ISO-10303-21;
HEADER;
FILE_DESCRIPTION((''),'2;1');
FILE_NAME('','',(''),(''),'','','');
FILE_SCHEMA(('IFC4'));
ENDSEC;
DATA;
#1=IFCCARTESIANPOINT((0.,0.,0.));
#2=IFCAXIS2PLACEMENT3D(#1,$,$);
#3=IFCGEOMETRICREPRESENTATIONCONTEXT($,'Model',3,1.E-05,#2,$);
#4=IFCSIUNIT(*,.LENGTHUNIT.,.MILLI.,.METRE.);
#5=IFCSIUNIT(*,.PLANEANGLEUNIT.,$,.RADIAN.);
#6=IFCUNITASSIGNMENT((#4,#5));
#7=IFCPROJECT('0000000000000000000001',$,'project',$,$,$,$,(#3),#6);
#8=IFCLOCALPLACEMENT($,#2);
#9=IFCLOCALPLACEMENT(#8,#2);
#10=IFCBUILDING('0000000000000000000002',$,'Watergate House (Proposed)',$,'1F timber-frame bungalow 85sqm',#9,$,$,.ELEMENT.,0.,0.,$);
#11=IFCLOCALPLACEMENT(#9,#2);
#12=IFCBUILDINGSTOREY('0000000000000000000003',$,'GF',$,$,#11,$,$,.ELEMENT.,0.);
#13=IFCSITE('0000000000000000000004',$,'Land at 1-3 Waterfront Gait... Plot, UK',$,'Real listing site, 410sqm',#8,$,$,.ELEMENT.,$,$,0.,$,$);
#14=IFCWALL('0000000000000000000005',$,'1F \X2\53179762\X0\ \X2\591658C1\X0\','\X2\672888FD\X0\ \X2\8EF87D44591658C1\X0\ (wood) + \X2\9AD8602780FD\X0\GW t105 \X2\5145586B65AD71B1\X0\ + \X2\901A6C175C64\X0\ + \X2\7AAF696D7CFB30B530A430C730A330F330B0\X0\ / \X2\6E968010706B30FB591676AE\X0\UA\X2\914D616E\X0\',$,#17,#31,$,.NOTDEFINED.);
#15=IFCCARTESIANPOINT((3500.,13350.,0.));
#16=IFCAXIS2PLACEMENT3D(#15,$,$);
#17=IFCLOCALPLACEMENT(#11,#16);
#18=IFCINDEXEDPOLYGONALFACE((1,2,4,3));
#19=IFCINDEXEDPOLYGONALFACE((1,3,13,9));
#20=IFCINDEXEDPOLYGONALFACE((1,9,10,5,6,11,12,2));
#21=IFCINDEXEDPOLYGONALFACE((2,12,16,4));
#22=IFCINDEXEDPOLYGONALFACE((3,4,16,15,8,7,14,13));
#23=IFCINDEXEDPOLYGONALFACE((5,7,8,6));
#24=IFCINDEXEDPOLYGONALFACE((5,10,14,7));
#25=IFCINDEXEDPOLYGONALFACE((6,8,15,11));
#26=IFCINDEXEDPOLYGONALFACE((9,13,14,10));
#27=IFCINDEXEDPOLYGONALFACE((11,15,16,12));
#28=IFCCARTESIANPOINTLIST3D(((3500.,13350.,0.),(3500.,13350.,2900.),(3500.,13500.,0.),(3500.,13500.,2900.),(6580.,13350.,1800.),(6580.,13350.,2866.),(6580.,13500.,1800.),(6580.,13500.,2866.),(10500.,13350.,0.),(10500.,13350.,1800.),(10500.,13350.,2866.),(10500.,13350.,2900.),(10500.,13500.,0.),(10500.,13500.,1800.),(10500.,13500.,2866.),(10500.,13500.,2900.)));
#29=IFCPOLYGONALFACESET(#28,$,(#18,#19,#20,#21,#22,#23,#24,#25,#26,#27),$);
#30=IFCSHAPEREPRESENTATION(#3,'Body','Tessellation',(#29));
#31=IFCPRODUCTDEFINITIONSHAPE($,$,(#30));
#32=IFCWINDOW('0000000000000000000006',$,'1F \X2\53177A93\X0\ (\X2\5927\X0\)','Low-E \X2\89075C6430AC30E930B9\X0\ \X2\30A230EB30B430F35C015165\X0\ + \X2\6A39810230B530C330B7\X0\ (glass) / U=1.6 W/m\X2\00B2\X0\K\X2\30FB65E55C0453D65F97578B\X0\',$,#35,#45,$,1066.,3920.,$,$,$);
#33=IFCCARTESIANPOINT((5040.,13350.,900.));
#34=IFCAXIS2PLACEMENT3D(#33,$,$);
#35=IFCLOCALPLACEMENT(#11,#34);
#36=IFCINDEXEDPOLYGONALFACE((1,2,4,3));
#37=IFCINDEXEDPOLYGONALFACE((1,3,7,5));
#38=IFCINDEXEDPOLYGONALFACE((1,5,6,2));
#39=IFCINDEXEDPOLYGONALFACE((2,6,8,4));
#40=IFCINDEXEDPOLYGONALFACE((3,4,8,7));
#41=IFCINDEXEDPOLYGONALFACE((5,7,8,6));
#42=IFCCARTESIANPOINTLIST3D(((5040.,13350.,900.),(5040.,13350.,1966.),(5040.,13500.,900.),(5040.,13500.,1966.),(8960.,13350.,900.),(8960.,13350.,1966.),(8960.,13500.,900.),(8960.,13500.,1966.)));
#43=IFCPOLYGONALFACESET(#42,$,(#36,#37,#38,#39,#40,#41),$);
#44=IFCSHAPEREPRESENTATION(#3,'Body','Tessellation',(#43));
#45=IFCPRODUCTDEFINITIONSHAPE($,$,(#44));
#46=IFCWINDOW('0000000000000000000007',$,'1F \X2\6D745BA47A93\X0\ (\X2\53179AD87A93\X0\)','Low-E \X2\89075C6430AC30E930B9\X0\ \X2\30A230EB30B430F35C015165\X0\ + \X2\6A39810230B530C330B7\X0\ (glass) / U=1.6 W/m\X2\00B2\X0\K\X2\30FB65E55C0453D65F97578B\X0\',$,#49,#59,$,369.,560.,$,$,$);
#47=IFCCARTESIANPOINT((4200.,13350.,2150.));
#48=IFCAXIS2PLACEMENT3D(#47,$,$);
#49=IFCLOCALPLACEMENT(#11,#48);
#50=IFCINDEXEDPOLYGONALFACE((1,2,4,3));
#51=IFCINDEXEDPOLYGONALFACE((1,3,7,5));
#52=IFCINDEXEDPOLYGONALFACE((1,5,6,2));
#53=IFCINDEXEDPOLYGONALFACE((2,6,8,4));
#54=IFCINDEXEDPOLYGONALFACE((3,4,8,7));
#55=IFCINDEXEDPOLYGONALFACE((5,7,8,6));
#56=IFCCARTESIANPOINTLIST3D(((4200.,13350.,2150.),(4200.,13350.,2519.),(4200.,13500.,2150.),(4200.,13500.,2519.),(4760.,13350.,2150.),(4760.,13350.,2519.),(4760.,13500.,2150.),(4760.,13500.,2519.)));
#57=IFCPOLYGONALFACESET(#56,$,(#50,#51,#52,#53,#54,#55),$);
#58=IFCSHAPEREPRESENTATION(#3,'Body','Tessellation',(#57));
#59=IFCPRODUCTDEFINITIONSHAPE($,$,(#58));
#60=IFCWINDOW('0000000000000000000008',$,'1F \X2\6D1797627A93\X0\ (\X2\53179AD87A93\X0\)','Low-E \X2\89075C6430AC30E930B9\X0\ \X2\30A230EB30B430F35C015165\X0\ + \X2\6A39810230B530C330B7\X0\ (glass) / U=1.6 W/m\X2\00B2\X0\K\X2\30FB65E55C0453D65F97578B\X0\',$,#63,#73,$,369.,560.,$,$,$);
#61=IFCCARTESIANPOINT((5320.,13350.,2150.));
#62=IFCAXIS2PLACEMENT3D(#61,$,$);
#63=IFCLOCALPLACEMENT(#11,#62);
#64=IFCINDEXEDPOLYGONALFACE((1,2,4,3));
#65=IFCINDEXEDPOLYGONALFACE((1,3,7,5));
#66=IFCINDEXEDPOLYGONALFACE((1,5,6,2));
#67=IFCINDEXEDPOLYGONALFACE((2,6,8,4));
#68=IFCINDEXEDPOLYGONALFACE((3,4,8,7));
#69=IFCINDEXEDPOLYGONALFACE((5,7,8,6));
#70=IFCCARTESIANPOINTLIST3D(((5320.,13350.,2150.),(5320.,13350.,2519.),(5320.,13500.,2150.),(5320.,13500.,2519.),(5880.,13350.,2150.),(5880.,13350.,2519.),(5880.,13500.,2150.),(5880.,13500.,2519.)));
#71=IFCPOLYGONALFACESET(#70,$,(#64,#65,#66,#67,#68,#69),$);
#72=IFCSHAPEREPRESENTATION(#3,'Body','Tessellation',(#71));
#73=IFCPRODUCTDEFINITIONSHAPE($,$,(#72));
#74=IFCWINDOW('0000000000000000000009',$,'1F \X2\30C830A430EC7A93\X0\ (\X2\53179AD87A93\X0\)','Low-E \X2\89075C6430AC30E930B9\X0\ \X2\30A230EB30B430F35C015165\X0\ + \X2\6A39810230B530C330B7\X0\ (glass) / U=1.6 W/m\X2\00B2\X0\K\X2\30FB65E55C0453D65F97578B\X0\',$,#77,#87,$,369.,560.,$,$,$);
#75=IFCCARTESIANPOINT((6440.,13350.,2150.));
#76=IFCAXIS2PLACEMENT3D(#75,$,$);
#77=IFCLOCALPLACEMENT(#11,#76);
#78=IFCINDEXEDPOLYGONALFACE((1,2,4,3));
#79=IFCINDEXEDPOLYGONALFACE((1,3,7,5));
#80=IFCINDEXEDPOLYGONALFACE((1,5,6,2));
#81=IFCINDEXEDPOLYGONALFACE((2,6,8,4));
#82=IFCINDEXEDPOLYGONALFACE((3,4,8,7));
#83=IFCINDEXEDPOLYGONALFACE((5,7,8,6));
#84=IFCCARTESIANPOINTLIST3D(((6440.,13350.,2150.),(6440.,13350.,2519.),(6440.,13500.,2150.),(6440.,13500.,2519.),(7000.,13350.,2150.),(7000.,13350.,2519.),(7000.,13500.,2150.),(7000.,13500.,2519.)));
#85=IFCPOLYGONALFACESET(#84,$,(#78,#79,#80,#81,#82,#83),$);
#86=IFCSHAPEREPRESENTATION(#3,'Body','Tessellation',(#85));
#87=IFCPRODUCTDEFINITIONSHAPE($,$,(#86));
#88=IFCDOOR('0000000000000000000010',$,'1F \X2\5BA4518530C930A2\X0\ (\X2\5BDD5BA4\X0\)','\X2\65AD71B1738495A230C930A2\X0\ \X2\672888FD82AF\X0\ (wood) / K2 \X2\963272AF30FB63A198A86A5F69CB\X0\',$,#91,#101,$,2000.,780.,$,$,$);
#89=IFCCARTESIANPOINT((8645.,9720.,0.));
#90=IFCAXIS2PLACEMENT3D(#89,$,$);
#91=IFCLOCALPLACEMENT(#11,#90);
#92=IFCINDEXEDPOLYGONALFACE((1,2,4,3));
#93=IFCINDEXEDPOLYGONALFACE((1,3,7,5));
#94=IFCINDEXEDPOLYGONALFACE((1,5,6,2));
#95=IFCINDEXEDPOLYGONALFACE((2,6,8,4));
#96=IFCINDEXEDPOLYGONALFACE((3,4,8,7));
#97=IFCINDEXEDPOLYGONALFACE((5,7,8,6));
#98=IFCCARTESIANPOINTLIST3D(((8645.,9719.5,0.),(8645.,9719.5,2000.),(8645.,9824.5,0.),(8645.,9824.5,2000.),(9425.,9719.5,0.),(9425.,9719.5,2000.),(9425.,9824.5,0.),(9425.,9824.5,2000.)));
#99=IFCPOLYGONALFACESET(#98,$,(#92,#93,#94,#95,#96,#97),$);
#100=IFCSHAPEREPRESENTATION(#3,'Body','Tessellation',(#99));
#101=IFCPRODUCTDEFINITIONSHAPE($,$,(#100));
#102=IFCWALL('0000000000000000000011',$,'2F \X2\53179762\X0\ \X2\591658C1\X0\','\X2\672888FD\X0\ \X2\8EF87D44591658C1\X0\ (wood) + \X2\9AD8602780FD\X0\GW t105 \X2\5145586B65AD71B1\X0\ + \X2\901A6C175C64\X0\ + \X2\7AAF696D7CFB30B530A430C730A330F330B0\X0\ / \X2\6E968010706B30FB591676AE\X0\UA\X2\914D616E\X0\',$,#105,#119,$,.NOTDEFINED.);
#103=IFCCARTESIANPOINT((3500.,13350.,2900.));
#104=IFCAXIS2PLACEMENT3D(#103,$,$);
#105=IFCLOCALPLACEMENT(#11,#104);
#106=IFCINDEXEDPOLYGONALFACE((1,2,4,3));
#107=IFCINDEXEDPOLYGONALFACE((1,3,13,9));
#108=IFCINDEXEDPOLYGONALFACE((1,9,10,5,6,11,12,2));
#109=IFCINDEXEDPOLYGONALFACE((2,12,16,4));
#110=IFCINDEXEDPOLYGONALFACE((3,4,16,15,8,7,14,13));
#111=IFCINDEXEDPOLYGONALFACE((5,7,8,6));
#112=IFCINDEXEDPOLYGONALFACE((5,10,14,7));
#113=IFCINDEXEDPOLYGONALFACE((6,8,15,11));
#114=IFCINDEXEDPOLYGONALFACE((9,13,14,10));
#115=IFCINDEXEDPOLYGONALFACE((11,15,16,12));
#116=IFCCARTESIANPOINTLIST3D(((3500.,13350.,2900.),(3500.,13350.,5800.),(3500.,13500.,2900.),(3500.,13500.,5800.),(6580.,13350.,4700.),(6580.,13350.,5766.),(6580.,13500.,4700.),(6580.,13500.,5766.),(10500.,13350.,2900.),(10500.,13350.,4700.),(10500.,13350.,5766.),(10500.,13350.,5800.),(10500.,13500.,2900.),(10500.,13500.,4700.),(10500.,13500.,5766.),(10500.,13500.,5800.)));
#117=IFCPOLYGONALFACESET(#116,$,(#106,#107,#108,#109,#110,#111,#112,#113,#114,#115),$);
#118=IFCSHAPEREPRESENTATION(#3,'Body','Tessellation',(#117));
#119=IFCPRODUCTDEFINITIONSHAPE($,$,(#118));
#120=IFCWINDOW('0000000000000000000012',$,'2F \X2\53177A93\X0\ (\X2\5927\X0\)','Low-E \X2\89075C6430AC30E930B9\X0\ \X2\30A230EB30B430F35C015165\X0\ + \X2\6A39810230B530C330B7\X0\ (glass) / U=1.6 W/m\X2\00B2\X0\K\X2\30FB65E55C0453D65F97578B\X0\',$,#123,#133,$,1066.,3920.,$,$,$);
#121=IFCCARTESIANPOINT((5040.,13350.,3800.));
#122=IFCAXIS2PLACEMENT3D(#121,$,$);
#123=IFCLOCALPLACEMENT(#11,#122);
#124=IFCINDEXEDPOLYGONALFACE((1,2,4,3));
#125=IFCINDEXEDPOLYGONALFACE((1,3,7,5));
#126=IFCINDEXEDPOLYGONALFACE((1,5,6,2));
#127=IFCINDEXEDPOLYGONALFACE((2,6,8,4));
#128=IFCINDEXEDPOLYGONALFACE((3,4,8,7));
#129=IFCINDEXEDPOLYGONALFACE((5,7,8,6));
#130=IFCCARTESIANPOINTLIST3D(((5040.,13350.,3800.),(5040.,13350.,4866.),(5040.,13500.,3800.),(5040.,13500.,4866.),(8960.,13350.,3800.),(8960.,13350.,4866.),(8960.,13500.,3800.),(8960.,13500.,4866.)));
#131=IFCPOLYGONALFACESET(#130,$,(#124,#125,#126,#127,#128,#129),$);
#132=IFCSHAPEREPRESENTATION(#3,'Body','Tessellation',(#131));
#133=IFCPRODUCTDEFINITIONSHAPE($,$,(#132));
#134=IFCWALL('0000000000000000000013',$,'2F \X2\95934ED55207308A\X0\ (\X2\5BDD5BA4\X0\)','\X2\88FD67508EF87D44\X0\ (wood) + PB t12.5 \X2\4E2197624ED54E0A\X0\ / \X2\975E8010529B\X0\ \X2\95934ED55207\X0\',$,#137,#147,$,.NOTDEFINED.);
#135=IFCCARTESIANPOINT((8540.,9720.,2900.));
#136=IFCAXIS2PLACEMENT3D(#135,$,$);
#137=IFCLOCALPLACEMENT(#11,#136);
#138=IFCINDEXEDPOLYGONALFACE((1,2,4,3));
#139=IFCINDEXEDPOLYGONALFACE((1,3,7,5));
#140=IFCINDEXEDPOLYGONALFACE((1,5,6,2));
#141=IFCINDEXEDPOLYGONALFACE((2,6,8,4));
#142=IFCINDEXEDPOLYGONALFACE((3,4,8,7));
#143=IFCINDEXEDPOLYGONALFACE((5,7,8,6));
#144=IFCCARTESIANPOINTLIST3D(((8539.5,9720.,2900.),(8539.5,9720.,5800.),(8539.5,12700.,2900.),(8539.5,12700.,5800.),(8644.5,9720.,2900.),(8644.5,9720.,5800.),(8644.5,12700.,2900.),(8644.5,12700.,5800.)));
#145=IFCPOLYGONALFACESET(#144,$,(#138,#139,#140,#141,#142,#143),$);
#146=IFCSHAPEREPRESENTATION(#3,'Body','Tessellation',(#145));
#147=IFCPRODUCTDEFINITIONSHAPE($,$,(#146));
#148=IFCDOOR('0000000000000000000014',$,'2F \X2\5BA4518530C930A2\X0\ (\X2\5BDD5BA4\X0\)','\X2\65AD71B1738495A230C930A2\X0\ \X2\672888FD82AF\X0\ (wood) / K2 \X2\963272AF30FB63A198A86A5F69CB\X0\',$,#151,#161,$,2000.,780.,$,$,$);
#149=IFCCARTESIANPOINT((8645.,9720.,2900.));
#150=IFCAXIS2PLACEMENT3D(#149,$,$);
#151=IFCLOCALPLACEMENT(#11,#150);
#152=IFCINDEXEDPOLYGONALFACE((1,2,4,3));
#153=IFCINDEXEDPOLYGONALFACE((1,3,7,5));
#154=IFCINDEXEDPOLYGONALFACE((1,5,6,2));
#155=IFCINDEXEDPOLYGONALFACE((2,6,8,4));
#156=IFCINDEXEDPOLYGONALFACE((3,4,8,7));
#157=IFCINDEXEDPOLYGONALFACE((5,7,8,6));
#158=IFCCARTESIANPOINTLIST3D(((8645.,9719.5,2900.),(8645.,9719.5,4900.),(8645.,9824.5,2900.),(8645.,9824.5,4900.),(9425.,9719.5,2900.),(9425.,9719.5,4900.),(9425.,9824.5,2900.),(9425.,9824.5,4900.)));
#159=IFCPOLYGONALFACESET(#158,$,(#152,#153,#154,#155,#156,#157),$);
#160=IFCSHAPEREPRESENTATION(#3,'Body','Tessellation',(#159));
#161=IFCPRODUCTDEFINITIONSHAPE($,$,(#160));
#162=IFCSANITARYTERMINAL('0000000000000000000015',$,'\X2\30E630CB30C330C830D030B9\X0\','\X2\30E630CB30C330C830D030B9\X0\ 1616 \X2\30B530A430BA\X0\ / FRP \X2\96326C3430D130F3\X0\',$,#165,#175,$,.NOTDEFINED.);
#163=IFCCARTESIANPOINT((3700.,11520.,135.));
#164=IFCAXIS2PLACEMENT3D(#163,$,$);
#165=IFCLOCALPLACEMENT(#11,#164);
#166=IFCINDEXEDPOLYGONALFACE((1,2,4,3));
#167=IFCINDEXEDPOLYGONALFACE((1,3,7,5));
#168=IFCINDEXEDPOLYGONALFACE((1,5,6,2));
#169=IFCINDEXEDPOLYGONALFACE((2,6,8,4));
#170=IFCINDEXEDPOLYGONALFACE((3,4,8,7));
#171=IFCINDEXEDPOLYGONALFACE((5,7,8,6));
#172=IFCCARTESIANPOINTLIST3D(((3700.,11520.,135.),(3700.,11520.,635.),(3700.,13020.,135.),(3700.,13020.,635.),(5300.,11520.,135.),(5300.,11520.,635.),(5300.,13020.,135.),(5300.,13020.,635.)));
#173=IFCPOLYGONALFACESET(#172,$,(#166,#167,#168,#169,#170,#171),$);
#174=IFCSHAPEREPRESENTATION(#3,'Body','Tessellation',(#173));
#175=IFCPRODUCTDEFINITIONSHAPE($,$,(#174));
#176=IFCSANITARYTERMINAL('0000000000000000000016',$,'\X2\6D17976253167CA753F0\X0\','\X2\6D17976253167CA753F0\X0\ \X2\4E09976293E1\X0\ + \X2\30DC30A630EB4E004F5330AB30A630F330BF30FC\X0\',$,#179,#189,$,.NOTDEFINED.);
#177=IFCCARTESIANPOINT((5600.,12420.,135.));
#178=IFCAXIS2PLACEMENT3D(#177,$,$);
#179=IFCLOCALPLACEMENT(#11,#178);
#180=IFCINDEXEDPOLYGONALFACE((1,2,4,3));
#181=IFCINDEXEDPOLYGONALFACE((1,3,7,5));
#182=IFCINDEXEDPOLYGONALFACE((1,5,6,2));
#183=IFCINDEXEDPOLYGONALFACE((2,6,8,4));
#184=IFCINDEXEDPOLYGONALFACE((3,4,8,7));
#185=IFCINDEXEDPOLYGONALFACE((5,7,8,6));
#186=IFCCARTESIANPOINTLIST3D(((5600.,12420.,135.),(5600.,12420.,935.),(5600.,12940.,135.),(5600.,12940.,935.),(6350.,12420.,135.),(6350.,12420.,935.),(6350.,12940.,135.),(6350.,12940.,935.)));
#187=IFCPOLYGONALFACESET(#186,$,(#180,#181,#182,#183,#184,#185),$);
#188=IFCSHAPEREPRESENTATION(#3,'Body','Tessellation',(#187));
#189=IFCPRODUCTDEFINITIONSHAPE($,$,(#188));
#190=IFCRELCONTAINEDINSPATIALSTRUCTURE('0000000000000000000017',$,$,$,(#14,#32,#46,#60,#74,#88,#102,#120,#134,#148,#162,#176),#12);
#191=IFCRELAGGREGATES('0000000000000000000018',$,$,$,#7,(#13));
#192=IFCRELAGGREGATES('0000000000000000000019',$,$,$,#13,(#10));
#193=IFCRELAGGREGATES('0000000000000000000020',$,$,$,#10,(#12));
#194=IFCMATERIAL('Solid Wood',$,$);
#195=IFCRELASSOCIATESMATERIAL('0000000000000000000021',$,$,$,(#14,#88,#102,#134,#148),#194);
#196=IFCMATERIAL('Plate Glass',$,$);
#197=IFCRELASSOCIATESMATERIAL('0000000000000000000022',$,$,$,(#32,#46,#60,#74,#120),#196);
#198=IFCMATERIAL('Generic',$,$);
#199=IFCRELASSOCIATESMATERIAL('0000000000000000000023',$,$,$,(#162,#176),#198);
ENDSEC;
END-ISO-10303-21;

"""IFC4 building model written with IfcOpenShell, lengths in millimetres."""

from ifc_helpers import new_model, si_unit, frame, frame_2d, origin, place, context, project, spatial, rectangle, extrude, material, element, fill, save


model = new_model("IFC4")

# Units and contexts
model_context = context("Model", 3, precision=1e-05, world=origin())
ifc_project = project(units=[si_unit("LENGTHUNIT", "METRE", prefix="MILLI"), si_unit("PLANEANGLEUNIT", "RADIAN")], contexts=[model_context])

# Site, building, storey
site_placement = place(None, origin())
site = spatial("IfcSite", under=ifc_project, at=site_placement, Name="Land at 1-3 Waterfront Gait... Plot, UK", ObjectType="Real listing site, 410sqm", CompositionType="ELEMENT", RefElevation=0.0)
building_placement = place(site_placement, origin())
building = spatial("IfcBuilding", under=site, at=building_placement, Name="Watergate House (Proposed)", ObjectType="1F timber-frame bungalow 85sqm", CompositionType="ELEMENT", ElevationOfRefHeight=0.0, ElevationOfTerrain=0.0)
storey_placement = place(building_placement, origin())
storey = spatial("IfcBuildingStorey", under=building, at=storey_placement, Name="GF", CompositionType="ELEMENT", Elevation=0.0)

# Wall, openings, windows
ifc_material_1 = material(Name="Solid Wood")
wall_1_placement = place(storey_placement, frame((3500.0, 13350.0, 0.0)))
wall_1 = element("IfcWall", 1, at=wall_1_placement, inside=storey, material=ifc_material_1, Name="1F 北面 外壁", Description="木製 軸組外壁 (wood) + 高性能GW t105 充填断熱 + 通気層 + 窯業系サイディング / 準耐火・外皮UA配慮", PredefinedType="NOTDEFINED", context=model_context, shape_type="SweptSolid", body=[
    extrude(rectangle(XDim=7000.0, YDim=150.0, at=frame_2d((3500.0, 75.0))), frame((3500.0, 13350.0, 0.0)), (0.0, 0.0, 1.0), 2900.0),
])
opening_1_placement = place(storey_placement, frame((5040.0, 13350.0, 900.0)))
opening_1 = element("IfcOpeningElement", 2, at=opening_1_placement, cuts=wall_1, PredefinedType="NOTDEFINED", context=model_context, shape_type="SweptSolid", body=[
    extrude(rectangle(XDim=3920.0, YDim=150.0, at=frame_2d((1960.0, 75.0))), frame((5040.0, 13350.0, 900.0)), (0.0, 0.0, 1.0), 1066.0),
])
opening_2_placement = place(storey_placement, frame((4200.0, 13350.0, 2150.0)))
opening_2 = element("IfcOpeningElement", 3, at=opening_2_placement, cuts=wall_1, PredefinedType="NOTDEFINED", context=model_context, shape_type="SweptSolid", body=[
    extrude(rectangle(XDim=560.0, YDim=150.0, at=frame_2d((280.0, 75.0))), frame((4200.0, 13350.0, 2150.0)), (0.0, 0.0, 1.0), 369.0),
])
opening_3_placement = place(storey_placement, frame((5320.0, 13350.0, 2150.0)))
opening_3 = element("IfcOpeningElement", 4, at=opening_3_placement, cuts=wall_1, PredefinedType="NOTDEFINED", context=model_context, shape_type="SweptSolid", body=[
    extrude(rectangle(XDim=560.0, YDim=150.0, at=frame_2d((280.0, 75.0))), frame((5320.0, 13350.0, 2150.0)), (0.0, 0.0, 1.0), 369.0),
])
opening_4_placement = place(storey_placement, frame((6440.0, 13350.0, 2150.0)))
opening_4 = element("IfcOpeningElement", 5, at=opening_4_placement, cuts=wall_1, PredefinedType="NOTDEFINED", context=model_context, shape_type="SweptSolid", body=[
    extrude(rectangle(XDim=560.0, YDim=150.0, at=frame_2d((280.0, 75.0))), frame((6440.0, 13350.0, 2150.0)), (0.0, 0.0, 1.0), 369.0),
])
ifc_material_2 = material(Name="Plate Glass")
window_1_placement = place(storey_placement, frame((5040.0, 13350.0, 900.0)))
window_1 = element("IfcWindow", 6, at=window_1_placement, inside=storey, material=ifc_material_2, Name="1F 北窓 (大)", Description="Low-E 複層ガラス アルゴン封入 + 樹脂サッシ (glass) / U=1.6 W/m²K・日射取得型", OverallHeight=1066.0, OverallWidth=3920.0, context=model_context, shape_type="SweptSolid", body=[
    extrude(rectangle(XDim=3920.0, YDim=150.0, at=frame_2d((1960.0, 75.0))), frame((5040.0, 13350.0, 900.0)), (0.0, 0.0, 1.0), 1066.0),
])
fill(opening_1, window_1)
window_2_placement = place(storey_placement, frame((4200.0, 13350.0, 2150.0)))
window_2 = element("IfcWindow", 7, at=window_2_placement, inside=storey, material=ifc_material_2, Name="1F 浴室窓 (北高窓)", Description="Low-E 複層ガラス アルゴン封入 + 樹脂サッシ (glass) / U=1.6 W/m²K・日射取得型", OverallHeight=369.0, OverallWidth=560.0, context=model_context, shape_type="SweptSolid", body=[
    extrude(rectangle(XDim=560.0, YDim=150.0, at=frame_2d((280.0, 75.0))), frame((4200.0, 13350.0, 2150.0)), (0.0, 0.0, 1.0), 369.0),
])
fill(opening_2, window_2)
window_3_placement = place(storey_placement, frame((5320.0, 13350.0, 2150.0)))
window_3 = element("IfcWindow", 8, at=window_3_placement, inside=storey, material=ifc_material_2, Name="1F 洗面窓 (北高窓)", Description="Low-E 複層ガラス アルゴン封入 + 樹脂サッシ (glass) / U=1.6 W/m²K・日射取得型", OverallHeight=369.0, OverallWidth=560.0, context=model_context, shape_type="SweptSolid", body=[
    extrude(rectangle(XDim=560.0, YDim=150.0, at=frame_2d((280.0, 75.0))), frame((5320.0, 13350.0, 2150.0)), (0.0, 0.0, 1.0), 369.0),
])
fill(opening_3, window_3)
window_4_placement = place(storey_placement, frame((6440.0, 13350.0, 2150.0)))
window_4 = element("IfcWindow", 9, at=window_4_placement, inside=storey, material=ifc_material_2, Name="1F トイレ窓 (北高窓)", Description="Low-E 複層ガラス アルゴン封入 + 樹脂サッシ (glass) / U=1.6 W/m²K・日射取得型", OverallHeight=369.0, OverallWidth=560.0, context=model_context, shape_type="SweptSolid", body=[
    extrude(rectangle(XDim=560.0, YDim=150.0, at=frame_2d((280.0, 75.0))), frame((6440.0, 13350.0, 2150.0)), (0.0, 0.0, 1.0), 369.0),
])
fill(opening_4, window_4)

# Door
door_1_placement = place(storey_placement, frame((8645.0, 9720.0, 0.0)))
element("IfcDoor", 10, at=door_1_placement, inside=storey, material=ifc_material_1, Name="1F 室内ドア (寝室)", Description="断熱玄関ドア 木製芯 (wood) / K2 防犯・採風機構", OverallHeight=2000.0, OverallWidth=780.0, context=model_context, shape_type="SweptSolid", body=[
    extrude(rectangle(XDim=780.0, YDim=105.0, at=frame_2d((390.0, 52.0))), frame((8645.0, 9720.0, 0.0)), (0.0, 0.0, 1.0), 2000.0),
])

# Wall, opening, window
wall_2_placement = place(storey_placement, frame((3500.0, 13350.0, 2900.0)))
wall_2 = element("IfcWall", 11, at=wall_2_placement, inside=storey, material=ifc_material_1, Name="2F 北面 外壁", Description="木製 軸組外壁 (wood) + 高性能GW t105 充填断熱 + 通気層 + 窯業系サイディング / 準耐火・外皮UA配慮", PredefinedType="NOTDEFINED", context=model_context, shape_type="SweptSolid", body=[
    extrude(rectangle(XDim=7000.0, YDim=150.0, at=frame_2d((3500.0, 75.0))), frame((3500.0, 13350.0, 2900.0)), (0.0, 0.0, 1.0), 2900.0),
])
opening_5_placement = place(storey_placement, frame((5040.0, 13350.0, 3800.0)))
opening_5 = element("IfcOpeningElement", 12, at=opening_5_placement, cuts=wall_2, PredefinedType="NOTDEFINED", context=model_context, shape_type="SweptSolid", body=[
    extrude(rectangle(XDim=3920.0, YDim=150.0, at=frame_2d((1960.0, 75.0))), frame((5040.0, 13350.0, 3800.0)), (0.0, 0.0, 1.0), 1066.0),
])
window_5_placement = place(storey_placement, frame((5040.0, 13350.0, 3800.0)))
window_5 = element("IfcWindow", 13, at=window_5_placement, inside=storey, material=ifc_material_2, Name="2F 北窓 (大)", Description="Low-E 複層ガラス アルゴン封入 + 樹脂サッシ (glass) / U=1.6 W/m²K・日射取得型", OverallHeight=1066.0, OverallWidth=3920.0, context=model_context, shape_type="SweptSolid", body=[
    extrude(rectangle(XDim=3920.0, YDim=150.0, at=frame_2d((1960.0, 75.0))), frame((5040.0, 13350.0, 3800.0)), (0.0, 0.0, 1.0), 1066.0),
])
fill(opening_5, window_5)

# Wall
wall_3_placement = place(storey_placement, frame((8540.0, 9720.0, 2900.0)))
element("IfcWall", 14, at=wall_3_placement, inside=storey, material=ifc_material_1, Name="2F 間仕切り (寝室)", Description="製材軸組 (wood) + PB t12.5 両面仕上 / 非耐力 間仕切", PredefinedType="NOTDEFINED", context=model_context, shape_type="SweptSolid", body=[
    extrude(rectangle(XDim=105.0, YDim=2980.0, at=frame_2d((52.0, 1490.0))), frame((8540.0, 9720.0, 2900.0)), (0.0, 0.0, 1.0), 2900.0),
])

# Door
door_2_placement = place(storey_placement, frame((8645.0, 9720.0, 2900.0)))
element("IfcDoor", 15, at=door_2_placement, inside=storey, material=ifc_material_1, Name="2F 室内ドア (寝室)", Description="断熱玄関ドア 木製芯 (wood) / K2 防犯・採風機構", OverallHeight=2000.0, OverallWidth=780.0, context=model_context, shape_type="SweptSolid", body=[
    extrude(rectangle(XDim=780.0, YDim=105.0, at=frame_2d((390.0, 52.0))), frame((8645.0, 9720.0, 2900.0)), (0.0, 0.0, 1.0), 2000.0),
])

# Sanitary terminals
ifc_material_3 = material(Name="Generic")
sanitary_terminal_1_placement = place(storey_placement, frame((3700.0, 11520.0, 135.0)))
element("IfcSanitaryTerminal", 16, at=sanitary_terminal_1_placement, inside=storey, material=ifc_material_3, Name="ユニットバス", Description="ユニットバス 1616 サイズ / FRP 防水パン", PredefinedType="NOTDEFINED", context=model_context, shape_type="SweptSolid", body=[
    extrude(rectangle(XDim=1600.0, YDim=1500.0, at=frame_2d((800.0, 750.0))), frame((3700.0, 11520.0, 135.0)), (0.0, 0.0, 1.0), 500.0),
])
sanitary_terminal_2_placement = place(storey_placement, frame((5600.0, 12420.0, 135.0)))
element("IfcSanitaryTerminal", 17, at=sanitary_terminal_2_placement, inside=storey, material=ifc_material_3, Name="洗面化粧台", Description="洗面化粧台 三面鏡 + ボウル一体カウンター", PredefinedType="NOTDEFINED", context=model_context, shape_type="SweptSolid", body=[
    extrude(rectangle(XDim=750.0, YDim=520.0, at=frame_2d((375.0, 260.0))), frame((5600.0, 12420.0, 135.0)), (0.0, 0.0, 1.0), 800.0),
])

save(model, "model.ifc")
